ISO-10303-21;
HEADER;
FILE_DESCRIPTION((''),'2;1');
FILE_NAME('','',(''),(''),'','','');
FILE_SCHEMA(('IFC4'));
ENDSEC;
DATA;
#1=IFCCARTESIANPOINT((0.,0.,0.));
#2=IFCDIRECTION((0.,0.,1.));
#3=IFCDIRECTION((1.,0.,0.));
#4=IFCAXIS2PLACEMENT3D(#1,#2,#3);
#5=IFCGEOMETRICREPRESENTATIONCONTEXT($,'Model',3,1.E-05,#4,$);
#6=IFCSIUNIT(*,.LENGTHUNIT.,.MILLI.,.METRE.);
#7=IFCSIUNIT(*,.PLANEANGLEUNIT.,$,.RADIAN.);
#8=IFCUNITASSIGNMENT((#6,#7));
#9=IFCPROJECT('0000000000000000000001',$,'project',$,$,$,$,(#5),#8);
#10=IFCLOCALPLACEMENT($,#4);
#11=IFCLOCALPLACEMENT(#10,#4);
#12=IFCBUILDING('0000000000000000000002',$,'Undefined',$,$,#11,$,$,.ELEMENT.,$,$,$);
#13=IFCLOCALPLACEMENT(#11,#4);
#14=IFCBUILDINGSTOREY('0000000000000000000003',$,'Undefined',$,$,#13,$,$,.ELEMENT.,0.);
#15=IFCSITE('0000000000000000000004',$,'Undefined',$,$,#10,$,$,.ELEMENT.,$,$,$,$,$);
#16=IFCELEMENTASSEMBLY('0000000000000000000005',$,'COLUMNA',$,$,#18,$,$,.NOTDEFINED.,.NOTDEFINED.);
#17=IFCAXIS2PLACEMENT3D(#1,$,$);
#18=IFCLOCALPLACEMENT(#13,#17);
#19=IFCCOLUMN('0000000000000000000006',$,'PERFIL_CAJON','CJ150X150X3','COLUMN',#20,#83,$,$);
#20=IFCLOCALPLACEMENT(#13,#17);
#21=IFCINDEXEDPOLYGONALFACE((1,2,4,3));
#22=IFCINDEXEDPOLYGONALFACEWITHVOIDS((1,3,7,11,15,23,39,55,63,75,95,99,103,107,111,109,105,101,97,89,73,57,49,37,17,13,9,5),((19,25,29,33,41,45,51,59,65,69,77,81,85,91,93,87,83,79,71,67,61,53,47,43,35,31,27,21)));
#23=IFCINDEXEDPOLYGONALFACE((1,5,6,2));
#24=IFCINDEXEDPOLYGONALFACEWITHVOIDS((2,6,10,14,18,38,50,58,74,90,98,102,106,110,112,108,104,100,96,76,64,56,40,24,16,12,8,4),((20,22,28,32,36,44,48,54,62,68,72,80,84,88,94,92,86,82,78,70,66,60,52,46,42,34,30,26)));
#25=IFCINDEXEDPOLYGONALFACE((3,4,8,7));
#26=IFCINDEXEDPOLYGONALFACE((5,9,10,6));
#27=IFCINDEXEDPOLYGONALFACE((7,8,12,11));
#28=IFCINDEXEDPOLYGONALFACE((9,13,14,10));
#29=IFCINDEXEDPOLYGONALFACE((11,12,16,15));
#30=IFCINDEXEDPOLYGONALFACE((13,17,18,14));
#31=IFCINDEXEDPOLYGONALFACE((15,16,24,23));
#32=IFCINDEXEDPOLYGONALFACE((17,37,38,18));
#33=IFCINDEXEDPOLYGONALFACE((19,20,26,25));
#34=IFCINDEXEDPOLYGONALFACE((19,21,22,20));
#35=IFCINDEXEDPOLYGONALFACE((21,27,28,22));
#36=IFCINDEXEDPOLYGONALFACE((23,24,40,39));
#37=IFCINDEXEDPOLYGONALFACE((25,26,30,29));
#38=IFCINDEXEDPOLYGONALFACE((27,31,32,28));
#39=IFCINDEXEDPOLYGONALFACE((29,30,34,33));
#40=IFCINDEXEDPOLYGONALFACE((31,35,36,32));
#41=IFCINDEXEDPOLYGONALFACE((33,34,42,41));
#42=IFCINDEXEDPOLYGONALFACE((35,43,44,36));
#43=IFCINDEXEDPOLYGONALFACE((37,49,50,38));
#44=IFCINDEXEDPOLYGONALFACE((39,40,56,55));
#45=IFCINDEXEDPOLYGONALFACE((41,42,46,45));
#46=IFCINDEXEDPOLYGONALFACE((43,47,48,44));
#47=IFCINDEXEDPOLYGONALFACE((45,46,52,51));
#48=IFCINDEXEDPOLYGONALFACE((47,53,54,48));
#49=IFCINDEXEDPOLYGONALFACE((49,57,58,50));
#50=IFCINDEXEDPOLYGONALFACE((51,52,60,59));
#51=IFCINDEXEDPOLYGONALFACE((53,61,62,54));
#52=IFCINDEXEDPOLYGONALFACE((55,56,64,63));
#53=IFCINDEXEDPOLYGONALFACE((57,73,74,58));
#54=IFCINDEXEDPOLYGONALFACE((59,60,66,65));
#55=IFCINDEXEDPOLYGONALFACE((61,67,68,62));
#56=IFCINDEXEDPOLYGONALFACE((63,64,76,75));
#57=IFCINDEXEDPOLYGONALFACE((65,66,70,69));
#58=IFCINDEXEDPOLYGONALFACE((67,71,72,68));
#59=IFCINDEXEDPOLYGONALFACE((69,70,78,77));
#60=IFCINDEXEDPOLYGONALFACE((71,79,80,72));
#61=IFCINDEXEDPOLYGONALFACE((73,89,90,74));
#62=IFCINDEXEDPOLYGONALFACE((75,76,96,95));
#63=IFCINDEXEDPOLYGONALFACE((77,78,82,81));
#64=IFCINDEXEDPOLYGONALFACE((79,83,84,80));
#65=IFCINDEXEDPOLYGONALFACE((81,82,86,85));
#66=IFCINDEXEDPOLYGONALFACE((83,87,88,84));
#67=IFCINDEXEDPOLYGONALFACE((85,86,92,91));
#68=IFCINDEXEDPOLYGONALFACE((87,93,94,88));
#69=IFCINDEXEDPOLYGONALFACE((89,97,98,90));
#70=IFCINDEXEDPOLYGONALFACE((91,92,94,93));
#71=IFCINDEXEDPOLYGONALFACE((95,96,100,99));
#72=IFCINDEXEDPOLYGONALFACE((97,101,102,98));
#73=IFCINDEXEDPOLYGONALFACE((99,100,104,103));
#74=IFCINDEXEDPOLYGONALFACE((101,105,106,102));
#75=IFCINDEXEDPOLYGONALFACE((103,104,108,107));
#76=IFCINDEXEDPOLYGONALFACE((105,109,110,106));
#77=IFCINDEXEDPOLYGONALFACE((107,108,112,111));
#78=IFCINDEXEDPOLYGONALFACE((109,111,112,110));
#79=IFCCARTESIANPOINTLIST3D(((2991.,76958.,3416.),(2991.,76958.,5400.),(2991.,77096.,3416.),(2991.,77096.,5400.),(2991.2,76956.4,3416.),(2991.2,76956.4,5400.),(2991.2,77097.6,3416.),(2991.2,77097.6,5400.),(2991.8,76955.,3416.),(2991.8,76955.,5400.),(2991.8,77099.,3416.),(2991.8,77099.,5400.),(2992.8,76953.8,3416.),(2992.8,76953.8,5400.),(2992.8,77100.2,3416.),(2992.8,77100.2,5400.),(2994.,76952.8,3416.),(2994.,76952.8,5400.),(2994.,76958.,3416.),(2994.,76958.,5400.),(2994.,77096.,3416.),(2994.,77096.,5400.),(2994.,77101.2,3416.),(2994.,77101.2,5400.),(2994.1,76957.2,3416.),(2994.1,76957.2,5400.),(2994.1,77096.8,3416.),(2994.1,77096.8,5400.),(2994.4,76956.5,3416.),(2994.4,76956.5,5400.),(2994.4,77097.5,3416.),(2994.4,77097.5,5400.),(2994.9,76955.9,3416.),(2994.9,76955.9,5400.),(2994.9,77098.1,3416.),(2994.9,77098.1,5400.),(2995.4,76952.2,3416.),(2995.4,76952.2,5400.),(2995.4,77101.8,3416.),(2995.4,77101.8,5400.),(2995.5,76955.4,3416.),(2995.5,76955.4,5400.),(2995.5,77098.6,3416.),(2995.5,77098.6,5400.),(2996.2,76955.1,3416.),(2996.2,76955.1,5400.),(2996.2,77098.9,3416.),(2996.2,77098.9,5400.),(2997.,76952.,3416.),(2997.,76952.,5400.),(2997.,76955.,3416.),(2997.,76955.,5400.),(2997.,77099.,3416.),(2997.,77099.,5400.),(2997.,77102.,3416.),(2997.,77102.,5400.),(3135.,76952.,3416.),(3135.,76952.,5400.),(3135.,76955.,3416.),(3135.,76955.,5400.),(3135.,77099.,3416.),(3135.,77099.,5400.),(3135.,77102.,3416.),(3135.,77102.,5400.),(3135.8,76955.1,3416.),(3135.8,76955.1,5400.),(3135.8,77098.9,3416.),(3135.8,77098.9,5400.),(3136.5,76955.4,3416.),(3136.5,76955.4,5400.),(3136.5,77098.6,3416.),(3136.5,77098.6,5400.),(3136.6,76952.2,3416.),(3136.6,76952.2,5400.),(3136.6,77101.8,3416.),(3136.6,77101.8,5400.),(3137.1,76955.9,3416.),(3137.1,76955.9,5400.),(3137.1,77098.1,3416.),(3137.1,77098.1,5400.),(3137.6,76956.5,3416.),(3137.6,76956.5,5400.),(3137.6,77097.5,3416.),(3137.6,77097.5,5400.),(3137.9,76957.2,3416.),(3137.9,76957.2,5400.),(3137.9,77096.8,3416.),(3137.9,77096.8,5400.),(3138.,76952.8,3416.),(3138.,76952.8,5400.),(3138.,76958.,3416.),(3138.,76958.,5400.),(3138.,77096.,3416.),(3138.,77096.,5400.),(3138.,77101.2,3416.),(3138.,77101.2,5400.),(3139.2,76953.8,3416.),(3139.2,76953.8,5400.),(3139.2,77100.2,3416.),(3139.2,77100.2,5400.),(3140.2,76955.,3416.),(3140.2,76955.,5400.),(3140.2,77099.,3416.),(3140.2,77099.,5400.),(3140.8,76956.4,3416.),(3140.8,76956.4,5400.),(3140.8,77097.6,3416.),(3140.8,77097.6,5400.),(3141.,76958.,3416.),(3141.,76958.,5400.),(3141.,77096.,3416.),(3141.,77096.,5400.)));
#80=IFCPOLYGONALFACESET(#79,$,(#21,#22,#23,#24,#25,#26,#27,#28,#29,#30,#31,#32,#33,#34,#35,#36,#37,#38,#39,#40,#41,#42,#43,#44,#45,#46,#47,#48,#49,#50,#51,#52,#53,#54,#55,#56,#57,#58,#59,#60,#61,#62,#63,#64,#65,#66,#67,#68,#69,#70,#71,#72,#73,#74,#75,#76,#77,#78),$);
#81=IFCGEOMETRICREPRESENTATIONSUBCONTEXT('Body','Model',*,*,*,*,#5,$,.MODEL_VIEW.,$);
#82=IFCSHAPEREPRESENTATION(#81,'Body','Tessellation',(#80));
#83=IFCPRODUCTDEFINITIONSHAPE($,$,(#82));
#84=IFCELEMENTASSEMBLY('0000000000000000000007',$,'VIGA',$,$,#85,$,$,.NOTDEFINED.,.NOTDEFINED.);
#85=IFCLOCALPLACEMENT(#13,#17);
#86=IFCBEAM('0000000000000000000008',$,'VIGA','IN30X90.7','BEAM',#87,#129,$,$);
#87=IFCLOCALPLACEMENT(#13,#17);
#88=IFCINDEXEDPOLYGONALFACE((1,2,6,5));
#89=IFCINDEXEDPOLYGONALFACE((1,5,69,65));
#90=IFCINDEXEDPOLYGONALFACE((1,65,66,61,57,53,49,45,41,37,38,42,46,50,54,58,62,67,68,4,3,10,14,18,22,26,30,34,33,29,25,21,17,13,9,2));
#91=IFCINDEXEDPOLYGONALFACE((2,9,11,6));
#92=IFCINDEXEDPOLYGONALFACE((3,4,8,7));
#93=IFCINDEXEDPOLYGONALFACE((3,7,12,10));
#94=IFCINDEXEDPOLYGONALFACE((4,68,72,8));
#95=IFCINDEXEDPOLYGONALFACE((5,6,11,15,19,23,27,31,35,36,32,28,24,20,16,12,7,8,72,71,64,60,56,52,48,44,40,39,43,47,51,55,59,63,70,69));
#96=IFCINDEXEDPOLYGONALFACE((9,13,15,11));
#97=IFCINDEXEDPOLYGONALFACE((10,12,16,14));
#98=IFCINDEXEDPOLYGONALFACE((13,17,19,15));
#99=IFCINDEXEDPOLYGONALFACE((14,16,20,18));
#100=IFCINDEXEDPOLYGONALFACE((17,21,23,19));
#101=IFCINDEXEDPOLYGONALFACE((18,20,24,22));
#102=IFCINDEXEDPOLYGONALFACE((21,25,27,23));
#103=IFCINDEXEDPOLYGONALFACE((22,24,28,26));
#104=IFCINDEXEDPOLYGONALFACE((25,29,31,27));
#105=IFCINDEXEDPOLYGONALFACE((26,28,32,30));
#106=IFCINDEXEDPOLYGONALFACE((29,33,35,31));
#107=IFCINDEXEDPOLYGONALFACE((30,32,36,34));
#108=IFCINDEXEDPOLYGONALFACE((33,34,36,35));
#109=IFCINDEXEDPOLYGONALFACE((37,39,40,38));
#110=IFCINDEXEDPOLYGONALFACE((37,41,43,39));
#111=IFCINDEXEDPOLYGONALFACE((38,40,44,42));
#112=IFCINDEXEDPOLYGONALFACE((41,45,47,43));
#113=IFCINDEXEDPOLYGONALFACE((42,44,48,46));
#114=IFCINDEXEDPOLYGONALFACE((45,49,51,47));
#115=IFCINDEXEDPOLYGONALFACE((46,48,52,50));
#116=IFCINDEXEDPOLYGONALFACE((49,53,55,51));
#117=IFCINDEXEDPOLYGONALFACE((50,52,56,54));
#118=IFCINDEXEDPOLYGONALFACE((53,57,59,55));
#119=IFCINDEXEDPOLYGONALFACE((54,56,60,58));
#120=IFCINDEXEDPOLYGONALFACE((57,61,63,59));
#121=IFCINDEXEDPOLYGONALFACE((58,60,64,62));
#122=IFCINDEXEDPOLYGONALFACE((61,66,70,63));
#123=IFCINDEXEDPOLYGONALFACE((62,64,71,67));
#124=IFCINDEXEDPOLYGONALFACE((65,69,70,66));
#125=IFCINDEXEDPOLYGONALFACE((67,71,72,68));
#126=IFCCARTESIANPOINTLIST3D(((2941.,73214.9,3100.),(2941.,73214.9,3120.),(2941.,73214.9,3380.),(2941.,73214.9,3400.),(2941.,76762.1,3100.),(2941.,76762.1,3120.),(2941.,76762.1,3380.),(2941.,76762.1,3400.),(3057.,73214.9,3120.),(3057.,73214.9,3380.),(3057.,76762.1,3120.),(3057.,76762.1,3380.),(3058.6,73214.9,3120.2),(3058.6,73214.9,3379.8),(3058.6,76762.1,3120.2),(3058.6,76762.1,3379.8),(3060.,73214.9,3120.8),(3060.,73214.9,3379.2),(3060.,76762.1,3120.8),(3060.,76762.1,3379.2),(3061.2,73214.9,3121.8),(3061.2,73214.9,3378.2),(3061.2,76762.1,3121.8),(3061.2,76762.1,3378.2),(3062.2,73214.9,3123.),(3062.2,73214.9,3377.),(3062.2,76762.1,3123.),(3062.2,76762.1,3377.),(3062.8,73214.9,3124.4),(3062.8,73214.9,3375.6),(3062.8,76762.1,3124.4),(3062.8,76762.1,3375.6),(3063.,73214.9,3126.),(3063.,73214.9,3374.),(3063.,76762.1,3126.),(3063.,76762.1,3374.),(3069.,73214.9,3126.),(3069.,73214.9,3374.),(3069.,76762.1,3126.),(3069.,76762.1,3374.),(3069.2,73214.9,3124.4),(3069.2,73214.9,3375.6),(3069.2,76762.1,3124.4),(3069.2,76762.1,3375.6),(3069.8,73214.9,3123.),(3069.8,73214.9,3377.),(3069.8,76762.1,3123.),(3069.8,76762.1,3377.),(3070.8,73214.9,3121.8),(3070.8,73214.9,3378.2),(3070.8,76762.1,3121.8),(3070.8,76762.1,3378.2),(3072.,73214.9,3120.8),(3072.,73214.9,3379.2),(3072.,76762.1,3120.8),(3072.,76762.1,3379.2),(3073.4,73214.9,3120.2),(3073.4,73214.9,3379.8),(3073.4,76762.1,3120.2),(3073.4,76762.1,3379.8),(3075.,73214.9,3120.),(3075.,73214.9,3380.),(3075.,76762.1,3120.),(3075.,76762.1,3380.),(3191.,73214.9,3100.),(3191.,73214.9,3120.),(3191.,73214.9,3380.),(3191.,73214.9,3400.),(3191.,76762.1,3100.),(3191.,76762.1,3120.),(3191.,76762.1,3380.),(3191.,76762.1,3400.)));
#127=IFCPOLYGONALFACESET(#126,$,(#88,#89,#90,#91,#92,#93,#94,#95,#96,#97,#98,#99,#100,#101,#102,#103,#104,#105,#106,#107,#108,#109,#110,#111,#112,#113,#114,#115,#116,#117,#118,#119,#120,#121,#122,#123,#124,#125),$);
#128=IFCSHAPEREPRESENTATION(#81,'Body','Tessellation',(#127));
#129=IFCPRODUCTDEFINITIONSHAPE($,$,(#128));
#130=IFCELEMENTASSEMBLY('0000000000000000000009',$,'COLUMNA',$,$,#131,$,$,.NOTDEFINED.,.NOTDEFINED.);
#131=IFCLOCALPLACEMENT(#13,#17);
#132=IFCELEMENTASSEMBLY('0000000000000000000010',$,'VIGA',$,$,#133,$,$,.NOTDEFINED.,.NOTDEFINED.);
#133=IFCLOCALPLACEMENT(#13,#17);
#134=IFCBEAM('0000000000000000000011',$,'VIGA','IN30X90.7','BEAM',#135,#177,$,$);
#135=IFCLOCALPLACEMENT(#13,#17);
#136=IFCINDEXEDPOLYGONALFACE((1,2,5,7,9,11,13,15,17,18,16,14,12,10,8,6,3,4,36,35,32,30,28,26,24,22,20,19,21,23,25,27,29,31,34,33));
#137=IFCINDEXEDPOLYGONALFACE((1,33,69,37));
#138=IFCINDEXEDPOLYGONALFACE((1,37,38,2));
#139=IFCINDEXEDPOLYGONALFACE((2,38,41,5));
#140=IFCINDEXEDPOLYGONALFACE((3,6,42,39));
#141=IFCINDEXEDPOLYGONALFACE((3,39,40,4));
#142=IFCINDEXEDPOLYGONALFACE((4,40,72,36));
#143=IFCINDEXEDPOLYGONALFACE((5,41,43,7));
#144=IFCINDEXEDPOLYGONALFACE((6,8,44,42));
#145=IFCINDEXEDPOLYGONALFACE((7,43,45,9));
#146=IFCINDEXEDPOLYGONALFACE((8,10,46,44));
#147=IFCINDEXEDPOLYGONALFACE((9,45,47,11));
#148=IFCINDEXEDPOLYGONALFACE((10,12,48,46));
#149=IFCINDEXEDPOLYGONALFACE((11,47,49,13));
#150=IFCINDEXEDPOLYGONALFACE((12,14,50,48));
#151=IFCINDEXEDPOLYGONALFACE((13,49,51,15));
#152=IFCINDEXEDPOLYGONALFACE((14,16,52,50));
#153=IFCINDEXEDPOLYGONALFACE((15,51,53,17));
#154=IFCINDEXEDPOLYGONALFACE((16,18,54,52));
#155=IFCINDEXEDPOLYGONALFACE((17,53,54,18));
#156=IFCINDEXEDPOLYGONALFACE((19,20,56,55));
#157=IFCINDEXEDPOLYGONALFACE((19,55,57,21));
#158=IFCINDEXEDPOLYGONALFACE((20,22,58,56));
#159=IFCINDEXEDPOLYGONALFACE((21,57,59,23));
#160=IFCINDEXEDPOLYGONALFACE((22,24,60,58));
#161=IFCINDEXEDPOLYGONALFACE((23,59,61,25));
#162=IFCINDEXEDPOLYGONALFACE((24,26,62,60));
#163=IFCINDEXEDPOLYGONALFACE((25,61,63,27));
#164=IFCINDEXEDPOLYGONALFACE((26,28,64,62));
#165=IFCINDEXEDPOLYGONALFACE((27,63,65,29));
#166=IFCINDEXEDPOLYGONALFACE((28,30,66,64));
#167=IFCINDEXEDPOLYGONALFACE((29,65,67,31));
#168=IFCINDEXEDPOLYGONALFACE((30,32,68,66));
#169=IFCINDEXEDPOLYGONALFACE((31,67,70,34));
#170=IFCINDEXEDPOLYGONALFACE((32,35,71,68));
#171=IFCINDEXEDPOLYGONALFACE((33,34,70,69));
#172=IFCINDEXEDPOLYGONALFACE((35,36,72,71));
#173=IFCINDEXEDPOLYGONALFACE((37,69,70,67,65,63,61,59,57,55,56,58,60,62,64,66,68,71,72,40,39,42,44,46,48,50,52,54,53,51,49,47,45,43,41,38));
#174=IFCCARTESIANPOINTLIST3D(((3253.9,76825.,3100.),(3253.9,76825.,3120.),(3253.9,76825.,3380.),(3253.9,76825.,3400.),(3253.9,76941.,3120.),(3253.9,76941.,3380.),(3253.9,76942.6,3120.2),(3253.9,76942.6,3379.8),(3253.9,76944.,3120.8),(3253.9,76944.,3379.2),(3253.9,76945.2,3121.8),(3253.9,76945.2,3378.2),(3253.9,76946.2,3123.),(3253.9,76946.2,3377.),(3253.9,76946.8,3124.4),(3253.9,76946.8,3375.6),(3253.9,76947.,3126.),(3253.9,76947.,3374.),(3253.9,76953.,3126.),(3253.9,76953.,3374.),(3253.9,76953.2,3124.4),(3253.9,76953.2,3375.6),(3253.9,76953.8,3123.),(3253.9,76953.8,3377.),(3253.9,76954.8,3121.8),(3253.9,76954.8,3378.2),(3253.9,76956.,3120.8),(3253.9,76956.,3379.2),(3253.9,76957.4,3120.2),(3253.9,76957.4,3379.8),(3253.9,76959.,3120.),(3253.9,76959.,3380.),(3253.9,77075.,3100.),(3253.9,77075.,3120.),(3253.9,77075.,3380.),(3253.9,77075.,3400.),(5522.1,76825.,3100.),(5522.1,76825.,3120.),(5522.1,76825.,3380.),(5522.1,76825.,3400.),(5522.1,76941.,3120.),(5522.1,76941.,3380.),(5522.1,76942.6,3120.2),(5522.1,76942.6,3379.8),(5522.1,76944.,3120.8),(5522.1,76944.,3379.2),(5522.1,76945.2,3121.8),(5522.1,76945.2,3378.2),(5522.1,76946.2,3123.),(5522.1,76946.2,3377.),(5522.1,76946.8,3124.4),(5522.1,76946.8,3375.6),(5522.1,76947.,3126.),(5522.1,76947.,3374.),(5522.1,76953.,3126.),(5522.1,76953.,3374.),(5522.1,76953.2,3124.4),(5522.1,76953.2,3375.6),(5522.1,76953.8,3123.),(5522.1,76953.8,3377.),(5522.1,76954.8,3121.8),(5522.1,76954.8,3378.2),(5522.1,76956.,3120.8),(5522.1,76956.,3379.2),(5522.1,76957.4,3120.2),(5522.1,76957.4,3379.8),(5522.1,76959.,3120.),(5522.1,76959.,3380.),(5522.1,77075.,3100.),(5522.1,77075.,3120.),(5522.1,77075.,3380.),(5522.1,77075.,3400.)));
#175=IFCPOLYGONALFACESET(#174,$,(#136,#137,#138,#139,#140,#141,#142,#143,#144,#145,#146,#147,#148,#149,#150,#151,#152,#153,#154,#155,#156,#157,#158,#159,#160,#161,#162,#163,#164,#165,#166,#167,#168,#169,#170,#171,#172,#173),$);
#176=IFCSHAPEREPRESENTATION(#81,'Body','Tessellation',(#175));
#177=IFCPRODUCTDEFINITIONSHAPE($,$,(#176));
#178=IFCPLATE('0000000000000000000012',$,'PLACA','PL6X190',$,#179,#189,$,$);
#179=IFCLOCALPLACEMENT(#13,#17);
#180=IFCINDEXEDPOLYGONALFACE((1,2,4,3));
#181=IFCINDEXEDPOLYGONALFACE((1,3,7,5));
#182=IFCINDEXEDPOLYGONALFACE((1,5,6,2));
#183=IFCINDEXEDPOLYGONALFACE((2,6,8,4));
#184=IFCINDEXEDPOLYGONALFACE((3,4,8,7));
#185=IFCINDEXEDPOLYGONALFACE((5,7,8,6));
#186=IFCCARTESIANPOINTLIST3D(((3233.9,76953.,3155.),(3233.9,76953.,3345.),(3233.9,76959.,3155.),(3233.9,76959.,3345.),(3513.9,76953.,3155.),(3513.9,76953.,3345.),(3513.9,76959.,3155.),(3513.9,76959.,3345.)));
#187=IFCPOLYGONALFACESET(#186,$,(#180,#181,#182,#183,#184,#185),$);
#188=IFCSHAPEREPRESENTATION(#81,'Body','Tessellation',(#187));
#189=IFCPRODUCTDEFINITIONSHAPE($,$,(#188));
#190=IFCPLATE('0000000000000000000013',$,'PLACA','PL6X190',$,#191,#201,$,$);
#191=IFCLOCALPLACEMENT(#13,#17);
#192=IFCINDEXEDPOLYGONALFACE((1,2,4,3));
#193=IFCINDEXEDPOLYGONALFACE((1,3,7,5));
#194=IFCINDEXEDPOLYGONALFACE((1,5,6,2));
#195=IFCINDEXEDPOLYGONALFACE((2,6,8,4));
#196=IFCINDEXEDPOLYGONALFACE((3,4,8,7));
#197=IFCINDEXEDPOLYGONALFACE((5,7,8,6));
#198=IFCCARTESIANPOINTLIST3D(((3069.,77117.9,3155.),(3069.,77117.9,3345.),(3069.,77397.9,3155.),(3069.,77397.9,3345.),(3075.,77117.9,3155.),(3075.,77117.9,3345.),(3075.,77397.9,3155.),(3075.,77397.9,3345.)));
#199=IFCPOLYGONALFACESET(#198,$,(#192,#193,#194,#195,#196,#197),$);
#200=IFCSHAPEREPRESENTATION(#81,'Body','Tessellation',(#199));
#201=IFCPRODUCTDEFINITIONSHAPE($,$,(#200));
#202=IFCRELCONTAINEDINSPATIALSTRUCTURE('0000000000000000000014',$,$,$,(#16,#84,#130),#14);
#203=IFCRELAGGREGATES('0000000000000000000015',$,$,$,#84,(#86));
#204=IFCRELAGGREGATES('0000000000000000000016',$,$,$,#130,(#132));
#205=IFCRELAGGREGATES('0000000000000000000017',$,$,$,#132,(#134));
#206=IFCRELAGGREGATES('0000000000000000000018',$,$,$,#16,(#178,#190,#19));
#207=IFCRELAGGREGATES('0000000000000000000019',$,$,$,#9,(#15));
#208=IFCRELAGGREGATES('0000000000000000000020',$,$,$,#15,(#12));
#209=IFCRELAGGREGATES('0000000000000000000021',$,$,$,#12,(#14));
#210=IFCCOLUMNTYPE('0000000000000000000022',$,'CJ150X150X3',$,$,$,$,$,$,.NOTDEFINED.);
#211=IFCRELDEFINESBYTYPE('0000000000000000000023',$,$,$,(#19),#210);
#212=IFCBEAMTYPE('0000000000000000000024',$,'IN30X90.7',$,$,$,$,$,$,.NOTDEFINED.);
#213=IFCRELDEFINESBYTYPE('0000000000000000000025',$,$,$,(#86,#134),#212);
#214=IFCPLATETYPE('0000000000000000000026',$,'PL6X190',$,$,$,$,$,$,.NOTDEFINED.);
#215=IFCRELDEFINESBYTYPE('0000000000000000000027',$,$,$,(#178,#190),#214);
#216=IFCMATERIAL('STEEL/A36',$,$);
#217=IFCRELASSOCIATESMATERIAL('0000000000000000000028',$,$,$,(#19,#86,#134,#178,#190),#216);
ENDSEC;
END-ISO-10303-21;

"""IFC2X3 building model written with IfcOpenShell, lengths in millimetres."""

from ifc_helpers import new_model, si_unit, frame, origin_with_axes, origin_2d_with_axis, place, context, subcontext, project, spatial, polyline, hollow_rectangle, i_section, outline, extrude, material, type_object, element, aggregate, save


model = new_model("IFC2X3")

# Units and contexts
model_context = context("Model", 3, precision=1e-05, world=origin_with_axes())
body_context = subcontext(model_context, "Body", "Model", "MODEL_VIEW")
ifc_project = project(units=[si_unit("LENGTHUNIT", "METRE", prefix="MILLI"), si_unit("PLANEANGLEUNIT", "RADIAN")], contexts=[model_context])

# Site, building, storey
site_placement = place(None, origin_with_axes())
site = spatial("IfcSite", under=ifc_project, at=site_placement, Name="Undefined", CompositionType="ELEMENT")
building_placement = place(site_placement, origin_with_axes())
building = spatial("IfcBuilding", under=site, at=building_placement, Name="Undefined", CompositionType="ELEMENT")
storey_placement = place(building_placement, origin_with_axes())
storey = spatial("IfcBuildingStorey", under=building, at=storey_placement, Name="Undefined", CompositionType="ELEMENT", Elevation=0.0)

# Element assembly, column
assembly_1_placement = place(storey_placement, origin_with_axes())
assembly_1 = element("IfcElementAssembly", 1, at=assembly_1_placement, inside=storey, Name="COLUMNA", AssemblyPlace="NOTDEFINED", PredefinedType="NOTDEFINED")
ifc_material_1 = material(Name="STEEL/A36")
column_type = type_object("IfcColumnType", Name="CJ150X150X3", PredefinedType="NOTDEFINED")
column_placement = place(assembly_1_placement, frame((3066.0, 77027.0, 3416.0), z_axis=(0.0, 0.0, 1.0), x_axis=(-1.0, 0.0, 0.0)))
column = element("IfcColumn", 2, at=column_placement, type_object=column_type, material=ifc_material_1, Name="PERFIL_CAJON", Description="CJ150X150X3", ObjectType="COLUMN", context=body_context, shape_type="SweptSolid", body=[
    extrude(hollow_rectangle(XDim=150.0, YDim=150.0, WallThickness=3.0, InnerFilletRadius=3.0, OuterFilletRadius=6.0, at=origin_2d_with_axis()), frame((0.0, 0.0, 1984.0), z_axis=(0.0, 0.0, -1.0), x_axis=(0.0, 1.0, 0.0)), (0.0, 0.0, 1.0), 1984.0),
])

# Element assembly, beam
assembly_2_placement = place(storey_placement, origin_with_axes())
assembly_2 = element("IfcElementAssembly", 3, at=assembly_2_placement, inside=storey, Name="VIGA", AssemblyPlace="NOTDEFINED", PredefinedType="NOTDEFINED")
beam_type = type_object("IfcBeamType", Name="IN30X90.7", PredefinedType="NOTDEFINED")
beam_1_placement = place(assembly_2_placement, frame((3066.0, 76762.1, 3250.0), z_axis=(0.0, 0.0, 1.0), x_axis=(0.0, -1.0, 0.0)))
beam_1 = element("IfcBeam", 4, at=beam_1_placement, type_object=beam_type, material=ifc_material_1, Name="VIGA", Description="IN30X90.7", ObjectType="BEAM", context=body_context, shape_type="SweptSolid", body=[
    extrude(i_section(OverallWidth=250.0, OverallDepth=300.0, WebThickness=6.0, FlangeThickness=20.0, FilletRadius=6.0, at=origin_2d_with_axis()), frame((3547.2, 0.0, 0.0), z_axis=(-1.0, 0.0, 0.0), x_axis=(0.0, -1.0, 0.0)), (0.0, 0.0, 1.0), 3547.2),
])
aggregate(assembly_2, [beam_1])

# Element assemblies, beam
assembly_3_placement = place(storey_placement, origin_with_axes())
assembly_3 = element("IfcElementAssembly", 5, at=assembly_3_placement, inside=storey, Name="COLUMNA", AssemblyPlace="NOTDEFINED", PredefinedType="NOTDEFINED")
assembly_4_placement = place(assembly_3_placement, origin_with_axes())
assembly_4 = element("IfcElementAssembly", 6, at=assembly_4_placement, Name="VIGA", AssemblyPlace="NOTDEFINED", PredefinedType="NOTDEFINED")
aggregate(assembly_3, [assembly_4])
beam_2_placement = place(assembly_4_placement, frame((3253.9, 76950.0, 3250.0), z_axis=(0.0, 0.0, 1.0), x_axis=(1.0, 0.0, 0.0)))
beam_2 = element("IfcBeam", 7, at=beam_2_placement, type_object=beam_type, material=ifc_material_1, Name="VIGA", Description="IN30X90.7", ObjectType="BEAM", context=body_context, shape_type="SweptSolid", body=[
    extrude(i_section(OverallWidth=250.0, OverallDepth=300.0, WebThickness=6.0, FlangeThickness=20.0, FilletRadius=6.0, at=origin_2d_with_axis()), frame((2268.2, 0.0, 0.0), z_axis=(-1.0, 0.0, 0.0), x_axis=(0.0, -1.0, 0.0)), (0.0, 0.0, 1.0), 2268.2),
])
aggregate(assembly_4, [beam_2])

# Plates
plate_type = type_object("IfcPlateType", Name="PL6X190", PredefinedType="NOTDEFINED")
plate_1_placement = place(assembly_1_placement, frame((3513.9, 76956.0, 3250.0), z_axis=(0.0, 1.0, 0.0), x_axis=(-1.0, 0.0, 0.0)))
plate_1 = element("IfcPlate", 8, at=plate_1_placement, type_object=plate_type, material=ifc_material_1, Name="PLACA", Description="PL6X190", context=body_context, shape_type="SweptSolid", body=[
    extrude(outline(polyline([(0.0, -95.0), (0.0, 95.0), (280.0, 95.0), (280.0, -95.0), (0.0, -95.0)])), frame((0.0, 0.0, -3.0), z_axis=(0.0, 0.0, 1.0), x_axis=(1.0, 0.0, 0.0)), (0.0, 0.0, 1.0), 6.0),
])
plate_2_placement = place(assembly_1_placement, frame((3072.0, 77397.9, 3250.0), z_axis=(-1.0, 0.0, 0.0), x_axis=(0.0, -1.0, 0.0)))
plate_2 = element("IfcPlate", 9, at=plate_2_placement, type_object=plate_type, material=ifc_material_1, Name="PLACA", Description="PL6X190", context=body_context, shape_type="SweptSolid", body=[
    extrude(outline(polyline([(0.0, -95.0), (0.0, 95.0), (280.0, 95.0), (280.0, -95.0), (0.0, -95.0)])), frame((0.0, 0.0, -3.0), z_axis=(0.0, 0.0, 1.0), x_axis=(1.0, 0.0, 0.0)), (0.0, 0.0, 1.0), 6.0),
])

aggregate(assembly_1, [plate_1, plate_2, column])

save(model, "model.ifc")
